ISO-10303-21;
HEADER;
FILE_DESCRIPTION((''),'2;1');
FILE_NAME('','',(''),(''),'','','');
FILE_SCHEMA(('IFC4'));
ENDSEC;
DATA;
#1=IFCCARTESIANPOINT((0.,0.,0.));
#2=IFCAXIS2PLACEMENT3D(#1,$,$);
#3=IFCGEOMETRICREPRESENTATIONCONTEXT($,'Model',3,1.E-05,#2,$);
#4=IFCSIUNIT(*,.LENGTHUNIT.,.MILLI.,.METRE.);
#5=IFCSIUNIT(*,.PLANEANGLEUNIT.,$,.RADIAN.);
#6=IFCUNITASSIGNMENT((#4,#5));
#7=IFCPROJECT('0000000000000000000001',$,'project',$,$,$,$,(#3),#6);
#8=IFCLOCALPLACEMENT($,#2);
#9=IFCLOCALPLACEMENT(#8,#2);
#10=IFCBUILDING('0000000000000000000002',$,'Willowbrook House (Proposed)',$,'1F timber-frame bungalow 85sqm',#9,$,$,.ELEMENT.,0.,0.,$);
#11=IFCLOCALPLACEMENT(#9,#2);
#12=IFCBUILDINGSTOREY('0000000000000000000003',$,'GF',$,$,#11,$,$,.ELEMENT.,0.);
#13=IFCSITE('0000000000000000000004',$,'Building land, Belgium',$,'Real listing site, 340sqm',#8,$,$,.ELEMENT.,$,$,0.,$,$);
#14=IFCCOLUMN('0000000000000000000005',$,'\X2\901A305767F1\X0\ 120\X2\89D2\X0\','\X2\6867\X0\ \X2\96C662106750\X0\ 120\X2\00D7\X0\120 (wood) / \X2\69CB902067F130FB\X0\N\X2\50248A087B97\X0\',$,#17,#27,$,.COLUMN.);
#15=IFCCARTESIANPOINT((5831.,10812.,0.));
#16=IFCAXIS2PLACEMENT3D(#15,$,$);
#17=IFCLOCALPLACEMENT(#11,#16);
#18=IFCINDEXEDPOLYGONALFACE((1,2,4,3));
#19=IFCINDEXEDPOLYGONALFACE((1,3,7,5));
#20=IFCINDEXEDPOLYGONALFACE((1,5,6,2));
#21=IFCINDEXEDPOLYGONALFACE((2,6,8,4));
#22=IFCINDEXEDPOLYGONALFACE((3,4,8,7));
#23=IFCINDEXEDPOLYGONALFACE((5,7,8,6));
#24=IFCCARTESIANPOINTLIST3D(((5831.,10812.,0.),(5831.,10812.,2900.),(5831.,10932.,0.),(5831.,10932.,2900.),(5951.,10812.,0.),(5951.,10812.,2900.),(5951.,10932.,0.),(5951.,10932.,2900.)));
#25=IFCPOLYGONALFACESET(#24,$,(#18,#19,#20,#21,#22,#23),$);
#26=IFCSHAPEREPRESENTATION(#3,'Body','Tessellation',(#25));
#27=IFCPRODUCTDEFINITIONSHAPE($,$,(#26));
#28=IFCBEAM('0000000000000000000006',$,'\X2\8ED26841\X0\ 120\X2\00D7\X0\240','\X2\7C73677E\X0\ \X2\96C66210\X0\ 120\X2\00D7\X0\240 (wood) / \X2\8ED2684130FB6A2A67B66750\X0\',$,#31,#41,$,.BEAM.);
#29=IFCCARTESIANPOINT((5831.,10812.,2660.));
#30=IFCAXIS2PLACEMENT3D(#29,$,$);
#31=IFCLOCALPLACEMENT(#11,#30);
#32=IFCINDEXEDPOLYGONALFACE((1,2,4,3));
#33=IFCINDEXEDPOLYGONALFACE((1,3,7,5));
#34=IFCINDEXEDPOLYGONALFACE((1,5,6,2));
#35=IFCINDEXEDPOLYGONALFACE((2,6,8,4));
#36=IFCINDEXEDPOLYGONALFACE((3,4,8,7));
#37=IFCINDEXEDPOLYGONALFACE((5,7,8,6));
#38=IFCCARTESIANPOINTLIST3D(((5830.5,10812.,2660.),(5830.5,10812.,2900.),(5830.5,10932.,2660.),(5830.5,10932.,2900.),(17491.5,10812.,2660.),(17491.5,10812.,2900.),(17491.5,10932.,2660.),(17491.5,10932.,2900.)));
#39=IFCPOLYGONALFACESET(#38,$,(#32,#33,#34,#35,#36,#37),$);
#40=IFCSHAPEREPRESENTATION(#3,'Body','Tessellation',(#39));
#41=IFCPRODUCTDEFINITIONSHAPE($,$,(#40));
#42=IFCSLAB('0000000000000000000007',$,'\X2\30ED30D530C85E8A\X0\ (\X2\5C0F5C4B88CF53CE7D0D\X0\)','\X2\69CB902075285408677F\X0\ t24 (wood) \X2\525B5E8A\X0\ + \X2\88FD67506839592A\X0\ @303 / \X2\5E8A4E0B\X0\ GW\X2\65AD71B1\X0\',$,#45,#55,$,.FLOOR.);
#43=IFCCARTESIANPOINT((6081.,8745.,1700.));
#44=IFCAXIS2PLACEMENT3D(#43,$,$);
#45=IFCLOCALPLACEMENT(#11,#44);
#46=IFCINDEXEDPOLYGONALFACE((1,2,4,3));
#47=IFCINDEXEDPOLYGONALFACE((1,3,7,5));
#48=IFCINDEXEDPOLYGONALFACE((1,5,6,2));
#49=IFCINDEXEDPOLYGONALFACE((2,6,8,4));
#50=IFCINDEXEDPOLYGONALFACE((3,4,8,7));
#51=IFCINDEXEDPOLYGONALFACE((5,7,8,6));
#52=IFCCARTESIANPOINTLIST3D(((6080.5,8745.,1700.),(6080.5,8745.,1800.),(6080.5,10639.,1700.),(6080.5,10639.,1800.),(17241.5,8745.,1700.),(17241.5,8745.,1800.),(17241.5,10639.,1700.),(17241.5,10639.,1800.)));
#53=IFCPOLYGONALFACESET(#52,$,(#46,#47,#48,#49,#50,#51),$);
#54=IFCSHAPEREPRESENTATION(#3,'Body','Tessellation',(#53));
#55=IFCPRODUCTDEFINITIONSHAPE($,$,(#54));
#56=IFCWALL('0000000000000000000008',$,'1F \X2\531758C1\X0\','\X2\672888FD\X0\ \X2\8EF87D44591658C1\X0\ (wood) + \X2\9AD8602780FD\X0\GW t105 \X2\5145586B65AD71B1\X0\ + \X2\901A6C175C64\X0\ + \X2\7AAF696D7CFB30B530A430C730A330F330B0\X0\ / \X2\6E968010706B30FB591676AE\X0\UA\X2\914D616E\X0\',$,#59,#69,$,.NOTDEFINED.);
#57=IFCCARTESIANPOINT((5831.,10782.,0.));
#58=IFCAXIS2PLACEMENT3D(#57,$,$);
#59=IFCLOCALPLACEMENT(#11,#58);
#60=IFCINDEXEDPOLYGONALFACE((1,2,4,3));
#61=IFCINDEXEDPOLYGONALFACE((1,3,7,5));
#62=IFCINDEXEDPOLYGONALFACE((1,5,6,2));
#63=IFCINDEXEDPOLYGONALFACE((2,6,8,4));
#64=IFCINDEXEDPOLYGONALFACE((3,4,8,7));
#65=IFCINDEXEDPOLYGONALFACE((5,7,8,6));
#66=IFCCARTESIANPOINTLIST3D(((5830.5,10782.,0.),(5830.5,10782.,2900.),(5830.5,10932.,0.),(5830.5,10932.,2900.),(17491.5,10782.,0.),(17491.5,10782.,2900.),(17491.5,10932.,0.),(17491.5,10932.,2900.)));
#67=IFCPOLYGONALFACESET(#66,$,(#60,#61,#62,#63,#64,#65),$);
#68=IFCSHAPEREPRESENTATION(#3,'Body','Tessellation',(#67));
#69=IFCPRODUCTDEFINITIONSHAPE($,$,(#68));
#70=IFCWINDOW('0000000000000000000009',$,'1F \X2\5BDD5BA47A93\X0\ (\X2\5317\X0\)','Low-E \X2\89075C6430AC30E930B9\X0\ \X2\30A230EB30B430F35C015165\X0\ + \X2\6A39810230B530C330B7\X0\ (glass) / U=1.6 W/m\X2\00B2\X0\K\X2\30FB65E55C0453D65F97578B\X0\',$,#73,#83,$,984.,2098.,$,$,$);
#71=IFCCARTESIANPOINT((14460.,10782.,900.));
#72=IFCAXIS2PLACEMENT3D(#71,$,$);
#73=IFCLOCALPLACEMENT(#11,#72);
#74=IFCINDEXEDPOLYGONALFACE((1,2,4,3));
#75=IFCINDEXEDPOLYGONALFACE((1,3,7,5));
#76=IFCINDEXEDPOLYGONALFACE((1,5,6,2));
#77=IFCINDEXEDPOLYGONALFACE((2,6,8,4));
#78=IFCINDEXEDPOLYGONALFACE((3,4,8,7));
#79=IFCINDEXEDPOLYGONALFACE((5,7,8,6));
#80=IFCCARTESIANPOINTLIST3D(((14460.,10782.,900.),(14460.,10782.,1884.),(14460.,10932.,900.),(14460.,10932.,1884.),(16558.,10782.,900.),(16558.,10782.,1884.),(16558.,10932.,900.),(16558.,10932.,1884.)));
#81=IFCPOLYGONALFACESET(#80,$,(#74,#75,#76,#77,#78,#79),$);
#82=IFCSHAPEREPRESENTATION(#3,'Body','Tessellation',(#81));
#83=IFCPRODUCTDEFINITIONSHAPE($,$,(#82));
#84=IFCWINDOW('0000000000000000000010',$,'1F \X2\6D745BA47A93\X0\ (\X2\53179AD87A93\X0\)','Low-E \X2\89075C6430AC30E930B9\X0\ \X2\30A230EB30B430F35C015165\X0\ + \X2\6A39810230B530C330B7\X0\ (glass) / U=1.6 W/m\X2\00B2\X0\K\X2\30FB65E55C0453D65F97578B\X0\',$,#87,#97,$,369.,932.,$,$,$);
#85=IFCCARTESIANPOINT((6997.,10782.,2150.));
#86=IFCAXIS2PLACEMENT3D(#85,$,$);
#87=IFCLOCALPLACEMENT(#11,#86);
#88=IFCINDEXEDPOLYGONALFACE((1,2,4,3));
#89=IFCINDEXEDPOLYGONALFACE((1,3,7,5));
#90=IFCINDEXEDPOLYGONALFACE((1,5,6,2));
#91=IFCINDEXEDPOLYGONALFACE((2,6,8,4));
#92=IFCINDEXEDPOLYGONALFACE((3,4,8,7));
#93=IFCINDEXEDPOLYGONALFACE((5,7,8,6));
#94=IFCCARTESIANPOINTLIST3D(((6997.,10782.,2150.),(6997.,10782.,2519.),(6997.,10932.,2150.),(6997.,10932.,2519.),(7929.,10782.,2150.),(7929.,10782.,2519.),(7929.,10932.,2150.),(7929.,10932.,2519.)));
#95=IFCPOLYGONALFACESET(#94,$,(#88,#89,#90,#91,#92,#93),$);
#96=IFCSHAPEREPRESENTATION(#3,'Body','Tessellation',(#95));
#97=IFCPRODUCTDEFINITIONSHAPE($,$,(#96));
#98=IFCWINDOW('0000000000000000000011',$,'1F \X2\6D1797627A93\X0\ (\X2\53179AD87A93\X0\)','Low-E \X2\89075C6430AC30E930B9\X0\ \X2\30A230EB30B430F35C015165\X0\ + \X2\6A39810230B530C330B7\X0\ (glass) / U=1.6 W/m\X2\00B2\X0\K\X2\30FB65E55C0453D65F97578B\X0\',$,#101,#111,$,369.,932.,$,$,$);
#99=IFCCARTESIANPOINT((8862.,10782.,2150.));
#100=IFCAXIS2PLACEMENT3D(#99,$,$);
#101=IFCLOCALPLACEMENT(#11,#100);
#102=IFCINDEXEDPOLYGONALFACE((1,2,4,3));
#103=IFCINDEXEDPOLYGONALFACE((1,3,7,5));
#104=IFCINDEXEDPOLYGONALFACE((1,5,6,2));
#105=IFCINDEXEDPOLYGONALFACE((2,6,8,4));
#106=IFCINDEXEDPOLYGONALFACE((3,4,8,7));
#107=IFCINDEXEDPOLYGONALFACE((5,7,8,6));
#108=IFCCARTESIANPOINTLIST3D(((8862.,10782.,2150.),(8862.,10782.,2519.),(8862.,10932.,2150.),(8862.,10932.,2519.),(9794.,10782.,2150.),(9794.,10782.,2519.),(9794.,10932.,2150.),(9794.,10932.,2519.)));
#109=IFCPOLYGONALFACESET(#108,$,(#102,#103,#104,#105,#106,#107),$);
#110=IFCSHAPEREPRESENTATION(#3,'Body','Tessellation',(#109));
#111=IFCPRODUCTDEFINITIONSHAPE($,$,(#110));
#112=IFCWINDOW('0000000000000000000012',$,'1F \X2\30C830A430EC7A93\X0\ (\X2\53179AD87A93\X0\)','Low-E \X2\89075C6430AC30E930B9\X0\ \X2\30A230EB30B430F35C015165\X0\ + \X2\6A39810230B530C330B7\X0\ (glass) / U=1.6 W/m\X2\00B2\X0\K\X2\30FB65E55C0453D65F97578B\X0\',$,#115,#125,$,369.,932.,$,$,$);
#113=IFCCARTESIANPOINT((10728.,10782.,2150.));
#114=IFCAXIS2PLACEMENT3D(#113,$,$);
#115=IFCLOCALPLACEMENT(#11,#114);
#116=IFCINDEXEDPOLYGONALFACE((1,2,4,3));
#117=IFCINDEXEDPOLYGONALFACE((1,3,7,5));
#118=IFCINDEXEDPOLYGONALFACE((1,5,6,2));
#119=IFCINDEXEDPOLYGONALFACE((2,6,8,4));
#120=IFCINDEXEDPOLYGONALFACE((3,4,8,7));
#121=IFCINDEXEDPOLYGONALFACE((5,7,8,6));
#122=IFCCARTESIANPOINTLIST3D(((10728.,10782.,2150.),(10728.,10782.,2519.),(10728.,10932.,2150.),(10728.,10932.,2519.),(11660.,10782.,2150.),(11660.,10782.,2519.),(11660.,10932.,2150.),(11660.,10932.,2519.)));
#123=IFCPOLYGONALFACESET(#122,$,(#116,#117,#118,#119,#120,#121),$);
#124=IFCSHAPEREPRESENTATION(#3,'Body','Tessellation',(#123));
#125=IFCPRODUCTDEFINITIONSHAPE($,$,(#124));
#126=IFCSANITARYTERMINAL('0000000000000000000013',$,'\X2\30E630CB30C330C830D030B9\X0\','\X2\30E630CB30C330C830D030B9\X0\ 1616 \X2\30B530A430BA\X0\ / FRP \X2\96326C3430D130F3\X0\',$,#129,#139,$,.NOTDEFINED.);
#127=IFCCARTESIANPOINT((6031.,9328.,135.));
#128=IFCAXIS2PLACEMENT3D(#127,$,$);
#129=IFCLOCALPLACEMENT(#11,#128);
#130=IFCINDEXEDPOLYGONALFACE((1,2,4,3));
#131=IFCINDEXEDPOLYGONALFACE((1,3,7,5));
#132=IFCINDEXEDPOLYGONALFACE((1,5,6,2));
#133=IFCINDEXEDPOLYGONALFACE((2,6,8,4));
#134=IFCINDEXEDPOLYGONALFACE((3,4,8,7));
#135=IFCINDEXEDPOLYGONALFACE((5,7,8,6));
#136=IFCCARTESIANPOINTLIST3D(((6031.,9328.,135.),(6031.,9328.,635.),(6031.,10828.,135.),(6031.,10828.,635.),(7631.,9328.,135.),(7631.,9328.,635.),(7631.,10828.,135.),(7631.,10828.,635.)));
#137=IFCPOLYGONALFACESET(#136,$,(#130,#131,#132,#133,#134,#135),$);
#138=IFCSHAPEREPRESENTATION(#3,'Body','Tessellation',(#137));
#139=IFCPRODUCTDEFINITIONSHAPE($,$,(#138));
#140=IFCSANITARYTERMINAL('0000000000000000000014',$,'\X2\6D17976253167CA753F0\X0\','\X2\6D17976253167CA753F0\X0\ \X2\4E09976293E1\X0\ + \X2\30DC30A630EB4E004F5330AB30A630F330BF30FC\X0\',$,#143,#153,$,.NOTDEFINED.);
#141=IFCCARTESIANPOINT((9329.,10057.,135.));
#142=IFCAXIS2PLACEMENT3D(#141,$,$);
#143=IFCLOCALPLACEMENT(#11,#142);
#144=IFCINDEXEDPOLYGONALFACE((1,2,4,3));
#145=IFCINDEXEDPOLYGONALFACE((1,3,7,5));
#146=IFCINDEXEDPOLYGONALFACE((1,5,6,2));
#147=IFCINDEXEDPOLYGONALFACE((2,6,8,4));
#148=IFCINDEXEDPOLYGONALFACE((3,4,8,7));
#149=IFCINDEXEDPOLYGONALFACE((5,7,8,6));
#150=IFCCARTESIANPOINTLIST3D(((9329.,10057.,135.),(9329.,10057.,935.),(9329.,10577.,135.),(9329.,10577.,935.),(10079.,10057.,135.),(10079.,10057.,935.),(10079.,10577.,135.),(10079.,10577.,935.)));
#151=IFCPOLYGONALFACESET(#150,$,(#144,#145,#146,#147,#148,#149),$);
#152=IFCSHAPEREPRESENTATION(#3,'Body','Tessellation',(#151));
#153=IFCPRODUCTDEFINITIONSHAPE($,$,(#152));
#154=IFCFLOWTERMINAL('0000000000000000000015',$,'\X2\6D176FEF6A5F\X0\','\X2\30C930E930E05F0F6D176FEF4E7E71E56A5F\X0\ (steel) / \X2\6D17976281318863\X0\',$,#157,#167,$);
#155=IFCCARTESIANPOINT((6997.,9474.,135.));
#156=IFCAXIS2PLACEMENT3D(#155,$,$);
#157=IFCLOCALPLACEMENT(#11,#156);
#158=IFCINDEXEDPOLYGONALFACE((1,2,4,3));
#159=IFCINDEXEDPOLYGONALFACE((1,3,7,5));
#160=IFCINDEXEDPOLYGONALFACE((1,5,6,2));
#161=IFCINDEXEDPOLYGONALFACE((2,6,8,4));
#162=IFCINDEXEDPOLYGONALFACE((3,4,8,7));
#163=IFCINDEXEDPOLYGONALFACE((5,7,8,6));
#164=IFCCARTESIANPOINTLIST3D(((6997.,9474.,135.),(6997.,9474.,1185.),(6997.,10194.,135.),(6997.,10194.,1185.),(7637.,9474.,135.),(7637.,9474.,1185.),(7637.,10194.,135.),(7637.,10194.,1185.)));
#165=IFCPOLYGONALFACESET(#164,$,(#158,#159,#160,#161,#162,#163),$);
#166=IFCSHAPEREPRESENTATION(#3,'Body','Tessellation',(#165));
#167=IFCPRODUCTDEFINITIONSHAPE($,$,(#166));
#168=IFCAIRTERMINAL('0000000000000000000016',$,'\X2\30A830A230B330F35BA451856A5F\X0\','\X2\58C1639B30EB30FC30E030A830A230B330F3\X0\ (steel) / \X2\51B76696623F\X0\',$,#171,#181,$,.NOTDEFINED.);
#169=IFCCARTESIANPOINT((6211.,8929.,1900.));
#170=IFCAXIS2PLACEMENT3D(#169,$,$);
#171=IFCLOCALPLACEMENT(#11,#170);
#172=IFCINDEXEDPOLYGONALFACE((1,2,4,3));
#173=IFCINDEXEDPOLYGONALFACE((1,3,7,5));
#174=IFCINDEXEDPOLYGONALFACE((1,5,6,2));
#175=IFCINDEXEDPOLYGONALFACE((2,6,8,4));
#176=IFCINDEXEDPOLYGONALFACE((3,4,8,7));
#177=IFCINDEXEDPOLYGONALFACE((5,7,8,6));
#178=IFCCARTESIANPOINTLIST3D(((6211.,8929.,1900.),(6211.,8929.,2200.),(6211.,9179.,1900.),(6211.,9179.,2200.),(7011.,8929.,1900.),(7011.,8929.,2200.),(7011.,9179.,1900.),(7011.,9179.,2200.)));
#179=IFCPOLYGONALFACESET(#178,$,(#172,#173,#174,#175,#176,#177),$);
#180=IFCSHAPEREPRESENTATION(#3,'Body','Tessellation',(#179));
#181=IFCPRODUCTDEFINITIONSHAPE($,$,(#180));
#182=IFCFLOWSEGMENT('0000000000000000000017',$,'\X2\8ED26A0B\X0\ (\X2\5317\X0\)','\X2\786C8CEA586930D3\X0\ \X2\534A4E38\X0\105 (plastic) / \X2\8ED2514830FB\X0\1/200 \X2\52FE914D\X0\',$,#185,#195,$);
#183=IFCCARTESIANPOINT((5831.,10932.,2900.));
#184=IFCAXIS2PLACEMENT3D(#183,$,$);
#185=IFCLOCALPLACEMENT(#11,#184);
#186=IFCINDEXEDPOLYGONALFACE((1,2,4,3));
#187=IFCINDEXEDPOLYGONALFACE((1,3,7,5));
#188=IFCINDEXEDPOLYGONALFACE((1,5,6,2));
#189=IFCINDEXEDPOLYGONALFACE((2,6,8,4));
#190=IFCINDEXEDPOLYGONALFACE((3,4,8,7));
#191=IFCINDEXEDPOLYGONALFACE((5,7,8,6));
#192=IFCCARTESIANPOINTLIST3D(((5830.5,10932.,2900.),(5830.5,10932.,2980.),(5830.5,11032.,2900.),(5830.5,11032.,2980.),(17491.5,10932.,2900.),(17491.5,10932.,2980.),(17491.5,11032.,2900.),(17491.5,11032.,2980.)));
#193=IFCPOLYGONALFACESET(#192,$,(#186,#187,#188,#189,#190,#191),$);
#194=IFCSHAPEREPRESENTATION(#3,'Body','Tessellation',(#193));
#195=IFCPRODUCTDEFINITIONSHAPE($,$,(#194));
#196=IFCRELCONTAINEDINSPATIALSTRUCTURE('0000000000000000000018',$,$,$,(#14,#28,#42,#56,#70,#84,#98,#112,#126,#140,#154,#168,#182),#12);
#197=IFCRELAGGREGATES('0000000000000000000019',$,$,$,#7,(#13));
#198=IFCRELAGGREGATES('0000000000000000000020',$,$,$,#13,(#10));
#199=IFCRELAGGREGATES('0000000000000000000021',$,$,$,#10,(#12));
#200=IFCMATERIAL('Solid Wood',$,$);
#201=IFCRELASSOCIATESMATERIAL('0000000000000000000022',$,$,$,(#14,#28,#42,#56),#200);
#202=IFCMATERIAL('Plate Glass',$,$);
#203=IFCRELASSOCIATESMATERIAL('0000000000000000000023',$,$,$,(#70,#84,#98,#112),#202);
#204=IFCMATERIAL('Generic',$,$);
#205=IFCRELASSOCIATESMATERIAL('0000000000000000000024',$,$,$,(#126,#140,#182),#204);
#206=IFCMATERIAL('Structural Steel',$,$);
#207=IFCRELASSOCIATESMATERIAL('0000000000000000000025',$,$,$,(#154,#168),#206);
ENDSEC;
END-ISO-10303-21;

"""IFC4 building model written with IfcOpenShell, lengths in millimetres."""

from ifc_helpers import new_model, si_unit, frame, frame_2d, origin, place, context, project, spatial, rectangle, extrude, material, element, fill, save


model = new_model("IFC4")

# Units and contexts
model_context = context("Model", 3, precision=1e-05, world=origin())
ifc_project = project(units=[si_unit("LENGTHUNIT", "METRE", prefix="MILLI"), si_unit("PLANEANGLEUNIT", "RADIAN")], contexts=[model_context])

# Site, building, storey
site_placement = place(None, origin())
site = spatial("IfcSite", under=ifc_project, at=site_placement, Name="Building land, Belgium", ObjectType="Real listing site, 340sqm", CompositionType="ELEMENT", RefElevation=0.0)
building_placement = place(site_placement, origin())
building = spatial("IfcBuilding", under=site, at=building_placement, Name="Willowbrook House (Proposed)", ObjectType="1F timber-frame bungalow 85sqm", CompositionType="ELEMENT", ElevationOfRefHeight=0.0, ElevationOfTerrain=0.0)
storey_placement = place(building_placement, origin())
storey = spatial("IfcBuildingStorey", under=building, at=storey_placement, Name="GF", CompositionType="ELEMENT", Elevation=0.0)

# Column
ifc_material_1 = material(Name="Solid Wood")
column_1_placement = place(storey_placement, frame((5831.0, 10812.0, 0.0)))
element("IfcColumn", 1, at=column_1_placement, inside=storey, material=ifc_material_1, Name="通し柱 120角", Description="桧 集成材 120×120 (wood) / 構造柱・N値計算", PredefinedType="COLUMN", context=model_context, shape_type="SweptSolid", body=[
    extrude(rectangle(XDim=120.0, YDim=120.0, at=frame_2d((60.0, 60.0))), frame((5831.0, 10812.0, 0.0)), (0.0, 0.0, 1.0), 2900.0),
])

# Beam
beam_1_placement = place(storey_placement, frame((5831.0, 10812.0, 2660.0)))
element("IfcBeam", 2, at=beam_1_placement, inside=storey, material=ifc_material_1, Name="軒桁 120×240", Description="米松 集成 120×240 (wood) / 軒桁・横架材", PredefinedType="BEAM", context=model_context, shape_type="SweptSolid", body=[
    extrude(rectangle(XDim=11661.0, YDim=120.0, at=frame_2d((5830.0, 60.0))), frame((5831.0, 10812.0, 2660.0)), (0.0, 0.0, 1.0), 240.0),
])

# Slab
slab_placement = place(storey_placement, frame((6081.0, 8745.0, 1700.0)))
element("IfcSlab", 3, at=slab_placement, inside=storey, material=ifc_material_1, Name="ロフト床 (小屋裏収納)", Description="構造用合板 t24 (wood) 剛床 + 製材根太 @303 / 床下 GW断熱", PredefinedType="FLOOR", context=model_context, shape_type="SweptSolid", body=[
    extrude(rectangle(XDim=11161.0, YDim=1894.0, at=frame_2d((5580.0, 947.0))), frame((6081.0, 8745.0, 1700.0)), (0.0, 0.0, 1.0), 100.0),
])

# Wall, openings, windows
wall_1_placement = place(storey_placement, frame((5831.0, 10782.0, 0.0)))
wall_1 = element("IfcWall", 4, at=wall_1_placement, inside=storey, material=ifc_material_1, Name="1F 北壁", Description="木製 軸組外壁 (wood) + 高性能GW t105 充填断熱 + 通気層 + 窯業系サイディング / 準耐火・外皮UA配慮", PredefinedType="NOTDEFINED", context=model_context, shape_type="SweptSolid", body=[
    extrude(rectangle(XDim=11661.0, YDim=150.0, at=frame_2d((5830.0, 75.0))), frame((5831.0, 10782.0, 0.0)), (0.0, 0.0, 1.0), 2900.0),
])
opening_1_placement = place(storey_placement, frame((14460.0, 10782.0, 900.0)))
opening_1 = element("IfcOpeningElement", 5, at=opening_1_placement, cuts=wall_1, PredefinedType="NOTDEFINED", context=model_context, shape_type="SweptSolid", body=[
    extrude(rectangle(XDim=2098.0, YDim=150.0, at=frame_2d((1049.0, 75.0))), frame((14460.0, 10782.0, 900.0)), (0.0, 0.0, 1.0), 984.0),
])
opening_2_placement = place(storey_placement, frame((6997.0, 10782.0, 2150.0)))
opening_2 = element("IfcOpeningElement", 6, at=opening_2_placement, cuts=wall_1, PredefinedType="NOTDEFINED", context=model_context, shape_type="SweptSolid", body=[
    extrude(rectangle(XDim=932.0, YDim=150.0, at=frame_2d((466.0, 75.0))), frame((6997.0, 10782.0, 2150.0)), (0.0, 0.0, 1.0), 369.0),
])
opening_3_placement = place(storey_placement, frame((8862.0, 10782.0, 2150.0)))
opening_3 = element("IfcOpeningElement", 7, at=opening_3_placement, cuts=wall_1, PredefinedType="NOTDEFINED", context=model_context, shape_type="SweptSolid", body=[
    extrude(rectangle(XDim=932.0, YDim=150.0, at=frame_2d((466.0, 75.0))), frame((8862.0, 10782.0, 2150.0)), (0.0, 0.0, 1.0), 369.0),
])
opening_4_placement = place(storey_placement, frame((10728.0, 10782.0, 2150.0)))
opening_4 = element("IfcOpeningElement", 8, at=opening_4_placement, cuts=wall_1, PredefinedType="NOTDEFINED", context=model_context, shape_type="SweptSolid", body=[
    extrude(rectangle(XDim=932.0, YDim=150.0, at=frame_2d((466.0, 75.0))), frame((10728.0, 10782.0, 2150.0)), (0.0, 0.0, 1.0), 369.0),
])
ifc_material_2 = material(Name="Plate Glass")
window_1_placement = place(storey_placement, frame((14460.0, 10782.0, 900.0)))
window_1 = element("IfcWindow", 9, at=window_1_placement, inside=storey, material=ifc_material_2, Name="1F 寝室窓 (北)", Description="Low-E 複層ガラス アルゴン封入 + 樹脂サッシ (glass) / U=1.6 W/m²K・日射取得型", OverallHeight=984.0, OverallWidth=2098.0, context=model_context, shape_type="SweptSolid", body=[
    extrude(rectangle(XDim=2098.0, YDim=150.0, at=frame_2d((1049.0, 75.0))), frame((14460.0, 10782.0, 900.0)), (0.0, 0.0, 1.0), 984.0),
])
fill(opening_1, window_1)
window_2_placement = place(storey_placement, frame((6997.0, 10782.0, 2150.0)))
window_2 = element("IfcWindow", 10, at=window_2_placement, inside=storey, material=ifc_material_2, Name="1F 浴室窓 (北高窓)", Description="Low-E 複層ガラス アルゴン封入 + 樹脂サッシ (glass) / U=1.6 W/m²K・日射取得型", OverallHeight=369.0, OverallWidth=932.0, context=model_context, shape_type="SweptSolid", body=[
    extrude(rectangle(XDim=932.0, YDim=150.0, at=frame_2d((466.0, 75.0))), frame((6997.0, 10782.0, 2150.0)), (0.0, 0.0, 1.0), 369.0),
])
fill(opening_2, window_2)
window_3_placement = place(storey_placement, frame((8862.0, 10782.0, 2150.0)))
window_3 = element("IfcWindow", 11, at=window_3_placement, inside=storey, material=ifc_material_2, Name="1F 洗面窓 (北高窓)", Description="Low-E 複層ガラス アルゴン封入 + 樹脂サッシ (glass) / U=1.6 W/m²K・日射取得型", OverallHeight=369.0, OverallWidth=932.0, context=model_context, shape_type="SweptSolid", body=[
    extrude(rectangle(XDim=932.0, YDim=150.0, at=frame_2d((466.0, 75.0))), frame((8862.0, 10782.0, 2150.0)), (0.0, 0.0, 1.0), 369.0),
])
fill(opening_3, window_3)
window_4_placement = place(storey_placement, frame((10728.0, 10782.0, 2150.0)))
window_4 = element("IfcWindow", 12, at=window_4_placement, inside=storey, material=ifc_material_2, Name="1F トイレ窓 (北高窓)", Description="Low-E 複層ガラス アルゴン封入 + 樹脂サッシ (glass) / U=1.6 W/m²K・日射取得型", OverallHeight=369.0, OverallWidth=932.0, context=model_context, shape_type="SweptSolid", body=[
    extrude(rectangle(XDim=932.0, YDim=150.0, at=frame_2d((466.0, 75.0))), frame((10728.0, 10782.0, 2150.0)), (0.0, 0.0, 1.0), 369.0),
])
fill(opening_4, window_4)

# Shared definitions
ifc_material_3 = material(Name="Generic")

# Sanitary terminals
sanitary_terminal_1_placement = place(storey_placement, frame((6031.0, 9328.0, 135.0)))
element("IfcSanitaryTerminal", 13, at=sanitary_terminal_1_placement, inside=storey, material=ifc_material_3, Name="ユニットバス", Description="ユニットバス 1616 サイズ / FRP 防水パン", PredefinedType="NOTDEFINED", context=model_context, shape_type="SweptSolid", body=[
    extrude(rectangle(XDim=1600.0, YDim=1500.0, at=frame_2d((800.0, 750.0))), frame((6031.0, 9328.0, 135.0)), (0.0, 0.0, 1.0), 500.0),
])
sanitary_terminal_2_placement = place(storey_placement, frame((9329.0, 10057.0, 135.0)))
element("IfcSanitaryTerminal", 14, at=sanitary_terminal_2_placement, inside=storey, material=ifc_material_3, Name="洗面化粧台", Description="洗面化粧台 三面鏡 + ボウル一体カウンター", PredefinedType="NOTDEFINED", context=model_context, shape_type="SweptSolid", body=[
    extrude(rectangle(XDim=750.0, YDim=520.0, at=frame_2d((375.0, 260.0))), frame((9329.0, 10057.0, 135.0)), (0.0, 0.0, 1.0), 800.0),
])

# Flow terminal
ifc_material_4 = material(Name="Structural Steel")
flow_terminal_placement = place(storey_placement, frame((6997.0, 9474.0, 135.0)))
element("IfcFlowTerminal", 15, at=flow_terminal_placement, inside=storey, material=ifc_material_4, Name="洗濯機", Description="ドラム式洗濯乾燥機 (steel) / 洗面脱衣", context=model_context, shape_type="SweptSolid", body=[
    extrude(rectangle(XDim=640.0, YDim=720.0, at=frame_2d((320.0, 360.0))), frame((6997.0, 9474.0, 135.0)), (0.0, 0.0, 1.0), 1050.0),
])

# Air terminal
air_terminal_placement = place(storey_placement, frame((6211.0, 8929.0, 1900.0)))
element("IfcAirTerminal", 16, at=air_terminal_placement, inside=storey, material=ifc_material_4, Name="エアコン室内機", Description="壁掛ルームエアコン (steel) / 冷暖房", PredefinedType="NOTDEFINED", context=model_context, shape_type="SweptSolid", body=[
    extrude(rectangle(XDim=800.0, YDim=250.0, at=frame_2d((400.0, 125.0))), frame((6211.0, 8929.0, 1900.0)), (0.0, 0.0, 1.0), 300.0),
])

# Flow segment
flow_segment_1_placement = place(storey_placement, frame((5831.0, 10932.0, 2900.0)))
element("IfcFlowSegment", 17, at=flow_segment_1_placement, inside=storey, material=ifc_material_3, Name="軒樋 (北)", Description="硬質塩ビ 半丸105 (plastic) / 軒先・1/200 勾配", context=model_context, shape_type="SweptSolid", body=[
    extrude(rectangle(XDim=11661.0, YDim=100.0, at=frame_2d((5830.0, 50.0))), frame((5831.0, 10932.0, 2900.0)), (0.0, 0.0, 1.0), 80.0),
])

save(model, "model.ifc")
